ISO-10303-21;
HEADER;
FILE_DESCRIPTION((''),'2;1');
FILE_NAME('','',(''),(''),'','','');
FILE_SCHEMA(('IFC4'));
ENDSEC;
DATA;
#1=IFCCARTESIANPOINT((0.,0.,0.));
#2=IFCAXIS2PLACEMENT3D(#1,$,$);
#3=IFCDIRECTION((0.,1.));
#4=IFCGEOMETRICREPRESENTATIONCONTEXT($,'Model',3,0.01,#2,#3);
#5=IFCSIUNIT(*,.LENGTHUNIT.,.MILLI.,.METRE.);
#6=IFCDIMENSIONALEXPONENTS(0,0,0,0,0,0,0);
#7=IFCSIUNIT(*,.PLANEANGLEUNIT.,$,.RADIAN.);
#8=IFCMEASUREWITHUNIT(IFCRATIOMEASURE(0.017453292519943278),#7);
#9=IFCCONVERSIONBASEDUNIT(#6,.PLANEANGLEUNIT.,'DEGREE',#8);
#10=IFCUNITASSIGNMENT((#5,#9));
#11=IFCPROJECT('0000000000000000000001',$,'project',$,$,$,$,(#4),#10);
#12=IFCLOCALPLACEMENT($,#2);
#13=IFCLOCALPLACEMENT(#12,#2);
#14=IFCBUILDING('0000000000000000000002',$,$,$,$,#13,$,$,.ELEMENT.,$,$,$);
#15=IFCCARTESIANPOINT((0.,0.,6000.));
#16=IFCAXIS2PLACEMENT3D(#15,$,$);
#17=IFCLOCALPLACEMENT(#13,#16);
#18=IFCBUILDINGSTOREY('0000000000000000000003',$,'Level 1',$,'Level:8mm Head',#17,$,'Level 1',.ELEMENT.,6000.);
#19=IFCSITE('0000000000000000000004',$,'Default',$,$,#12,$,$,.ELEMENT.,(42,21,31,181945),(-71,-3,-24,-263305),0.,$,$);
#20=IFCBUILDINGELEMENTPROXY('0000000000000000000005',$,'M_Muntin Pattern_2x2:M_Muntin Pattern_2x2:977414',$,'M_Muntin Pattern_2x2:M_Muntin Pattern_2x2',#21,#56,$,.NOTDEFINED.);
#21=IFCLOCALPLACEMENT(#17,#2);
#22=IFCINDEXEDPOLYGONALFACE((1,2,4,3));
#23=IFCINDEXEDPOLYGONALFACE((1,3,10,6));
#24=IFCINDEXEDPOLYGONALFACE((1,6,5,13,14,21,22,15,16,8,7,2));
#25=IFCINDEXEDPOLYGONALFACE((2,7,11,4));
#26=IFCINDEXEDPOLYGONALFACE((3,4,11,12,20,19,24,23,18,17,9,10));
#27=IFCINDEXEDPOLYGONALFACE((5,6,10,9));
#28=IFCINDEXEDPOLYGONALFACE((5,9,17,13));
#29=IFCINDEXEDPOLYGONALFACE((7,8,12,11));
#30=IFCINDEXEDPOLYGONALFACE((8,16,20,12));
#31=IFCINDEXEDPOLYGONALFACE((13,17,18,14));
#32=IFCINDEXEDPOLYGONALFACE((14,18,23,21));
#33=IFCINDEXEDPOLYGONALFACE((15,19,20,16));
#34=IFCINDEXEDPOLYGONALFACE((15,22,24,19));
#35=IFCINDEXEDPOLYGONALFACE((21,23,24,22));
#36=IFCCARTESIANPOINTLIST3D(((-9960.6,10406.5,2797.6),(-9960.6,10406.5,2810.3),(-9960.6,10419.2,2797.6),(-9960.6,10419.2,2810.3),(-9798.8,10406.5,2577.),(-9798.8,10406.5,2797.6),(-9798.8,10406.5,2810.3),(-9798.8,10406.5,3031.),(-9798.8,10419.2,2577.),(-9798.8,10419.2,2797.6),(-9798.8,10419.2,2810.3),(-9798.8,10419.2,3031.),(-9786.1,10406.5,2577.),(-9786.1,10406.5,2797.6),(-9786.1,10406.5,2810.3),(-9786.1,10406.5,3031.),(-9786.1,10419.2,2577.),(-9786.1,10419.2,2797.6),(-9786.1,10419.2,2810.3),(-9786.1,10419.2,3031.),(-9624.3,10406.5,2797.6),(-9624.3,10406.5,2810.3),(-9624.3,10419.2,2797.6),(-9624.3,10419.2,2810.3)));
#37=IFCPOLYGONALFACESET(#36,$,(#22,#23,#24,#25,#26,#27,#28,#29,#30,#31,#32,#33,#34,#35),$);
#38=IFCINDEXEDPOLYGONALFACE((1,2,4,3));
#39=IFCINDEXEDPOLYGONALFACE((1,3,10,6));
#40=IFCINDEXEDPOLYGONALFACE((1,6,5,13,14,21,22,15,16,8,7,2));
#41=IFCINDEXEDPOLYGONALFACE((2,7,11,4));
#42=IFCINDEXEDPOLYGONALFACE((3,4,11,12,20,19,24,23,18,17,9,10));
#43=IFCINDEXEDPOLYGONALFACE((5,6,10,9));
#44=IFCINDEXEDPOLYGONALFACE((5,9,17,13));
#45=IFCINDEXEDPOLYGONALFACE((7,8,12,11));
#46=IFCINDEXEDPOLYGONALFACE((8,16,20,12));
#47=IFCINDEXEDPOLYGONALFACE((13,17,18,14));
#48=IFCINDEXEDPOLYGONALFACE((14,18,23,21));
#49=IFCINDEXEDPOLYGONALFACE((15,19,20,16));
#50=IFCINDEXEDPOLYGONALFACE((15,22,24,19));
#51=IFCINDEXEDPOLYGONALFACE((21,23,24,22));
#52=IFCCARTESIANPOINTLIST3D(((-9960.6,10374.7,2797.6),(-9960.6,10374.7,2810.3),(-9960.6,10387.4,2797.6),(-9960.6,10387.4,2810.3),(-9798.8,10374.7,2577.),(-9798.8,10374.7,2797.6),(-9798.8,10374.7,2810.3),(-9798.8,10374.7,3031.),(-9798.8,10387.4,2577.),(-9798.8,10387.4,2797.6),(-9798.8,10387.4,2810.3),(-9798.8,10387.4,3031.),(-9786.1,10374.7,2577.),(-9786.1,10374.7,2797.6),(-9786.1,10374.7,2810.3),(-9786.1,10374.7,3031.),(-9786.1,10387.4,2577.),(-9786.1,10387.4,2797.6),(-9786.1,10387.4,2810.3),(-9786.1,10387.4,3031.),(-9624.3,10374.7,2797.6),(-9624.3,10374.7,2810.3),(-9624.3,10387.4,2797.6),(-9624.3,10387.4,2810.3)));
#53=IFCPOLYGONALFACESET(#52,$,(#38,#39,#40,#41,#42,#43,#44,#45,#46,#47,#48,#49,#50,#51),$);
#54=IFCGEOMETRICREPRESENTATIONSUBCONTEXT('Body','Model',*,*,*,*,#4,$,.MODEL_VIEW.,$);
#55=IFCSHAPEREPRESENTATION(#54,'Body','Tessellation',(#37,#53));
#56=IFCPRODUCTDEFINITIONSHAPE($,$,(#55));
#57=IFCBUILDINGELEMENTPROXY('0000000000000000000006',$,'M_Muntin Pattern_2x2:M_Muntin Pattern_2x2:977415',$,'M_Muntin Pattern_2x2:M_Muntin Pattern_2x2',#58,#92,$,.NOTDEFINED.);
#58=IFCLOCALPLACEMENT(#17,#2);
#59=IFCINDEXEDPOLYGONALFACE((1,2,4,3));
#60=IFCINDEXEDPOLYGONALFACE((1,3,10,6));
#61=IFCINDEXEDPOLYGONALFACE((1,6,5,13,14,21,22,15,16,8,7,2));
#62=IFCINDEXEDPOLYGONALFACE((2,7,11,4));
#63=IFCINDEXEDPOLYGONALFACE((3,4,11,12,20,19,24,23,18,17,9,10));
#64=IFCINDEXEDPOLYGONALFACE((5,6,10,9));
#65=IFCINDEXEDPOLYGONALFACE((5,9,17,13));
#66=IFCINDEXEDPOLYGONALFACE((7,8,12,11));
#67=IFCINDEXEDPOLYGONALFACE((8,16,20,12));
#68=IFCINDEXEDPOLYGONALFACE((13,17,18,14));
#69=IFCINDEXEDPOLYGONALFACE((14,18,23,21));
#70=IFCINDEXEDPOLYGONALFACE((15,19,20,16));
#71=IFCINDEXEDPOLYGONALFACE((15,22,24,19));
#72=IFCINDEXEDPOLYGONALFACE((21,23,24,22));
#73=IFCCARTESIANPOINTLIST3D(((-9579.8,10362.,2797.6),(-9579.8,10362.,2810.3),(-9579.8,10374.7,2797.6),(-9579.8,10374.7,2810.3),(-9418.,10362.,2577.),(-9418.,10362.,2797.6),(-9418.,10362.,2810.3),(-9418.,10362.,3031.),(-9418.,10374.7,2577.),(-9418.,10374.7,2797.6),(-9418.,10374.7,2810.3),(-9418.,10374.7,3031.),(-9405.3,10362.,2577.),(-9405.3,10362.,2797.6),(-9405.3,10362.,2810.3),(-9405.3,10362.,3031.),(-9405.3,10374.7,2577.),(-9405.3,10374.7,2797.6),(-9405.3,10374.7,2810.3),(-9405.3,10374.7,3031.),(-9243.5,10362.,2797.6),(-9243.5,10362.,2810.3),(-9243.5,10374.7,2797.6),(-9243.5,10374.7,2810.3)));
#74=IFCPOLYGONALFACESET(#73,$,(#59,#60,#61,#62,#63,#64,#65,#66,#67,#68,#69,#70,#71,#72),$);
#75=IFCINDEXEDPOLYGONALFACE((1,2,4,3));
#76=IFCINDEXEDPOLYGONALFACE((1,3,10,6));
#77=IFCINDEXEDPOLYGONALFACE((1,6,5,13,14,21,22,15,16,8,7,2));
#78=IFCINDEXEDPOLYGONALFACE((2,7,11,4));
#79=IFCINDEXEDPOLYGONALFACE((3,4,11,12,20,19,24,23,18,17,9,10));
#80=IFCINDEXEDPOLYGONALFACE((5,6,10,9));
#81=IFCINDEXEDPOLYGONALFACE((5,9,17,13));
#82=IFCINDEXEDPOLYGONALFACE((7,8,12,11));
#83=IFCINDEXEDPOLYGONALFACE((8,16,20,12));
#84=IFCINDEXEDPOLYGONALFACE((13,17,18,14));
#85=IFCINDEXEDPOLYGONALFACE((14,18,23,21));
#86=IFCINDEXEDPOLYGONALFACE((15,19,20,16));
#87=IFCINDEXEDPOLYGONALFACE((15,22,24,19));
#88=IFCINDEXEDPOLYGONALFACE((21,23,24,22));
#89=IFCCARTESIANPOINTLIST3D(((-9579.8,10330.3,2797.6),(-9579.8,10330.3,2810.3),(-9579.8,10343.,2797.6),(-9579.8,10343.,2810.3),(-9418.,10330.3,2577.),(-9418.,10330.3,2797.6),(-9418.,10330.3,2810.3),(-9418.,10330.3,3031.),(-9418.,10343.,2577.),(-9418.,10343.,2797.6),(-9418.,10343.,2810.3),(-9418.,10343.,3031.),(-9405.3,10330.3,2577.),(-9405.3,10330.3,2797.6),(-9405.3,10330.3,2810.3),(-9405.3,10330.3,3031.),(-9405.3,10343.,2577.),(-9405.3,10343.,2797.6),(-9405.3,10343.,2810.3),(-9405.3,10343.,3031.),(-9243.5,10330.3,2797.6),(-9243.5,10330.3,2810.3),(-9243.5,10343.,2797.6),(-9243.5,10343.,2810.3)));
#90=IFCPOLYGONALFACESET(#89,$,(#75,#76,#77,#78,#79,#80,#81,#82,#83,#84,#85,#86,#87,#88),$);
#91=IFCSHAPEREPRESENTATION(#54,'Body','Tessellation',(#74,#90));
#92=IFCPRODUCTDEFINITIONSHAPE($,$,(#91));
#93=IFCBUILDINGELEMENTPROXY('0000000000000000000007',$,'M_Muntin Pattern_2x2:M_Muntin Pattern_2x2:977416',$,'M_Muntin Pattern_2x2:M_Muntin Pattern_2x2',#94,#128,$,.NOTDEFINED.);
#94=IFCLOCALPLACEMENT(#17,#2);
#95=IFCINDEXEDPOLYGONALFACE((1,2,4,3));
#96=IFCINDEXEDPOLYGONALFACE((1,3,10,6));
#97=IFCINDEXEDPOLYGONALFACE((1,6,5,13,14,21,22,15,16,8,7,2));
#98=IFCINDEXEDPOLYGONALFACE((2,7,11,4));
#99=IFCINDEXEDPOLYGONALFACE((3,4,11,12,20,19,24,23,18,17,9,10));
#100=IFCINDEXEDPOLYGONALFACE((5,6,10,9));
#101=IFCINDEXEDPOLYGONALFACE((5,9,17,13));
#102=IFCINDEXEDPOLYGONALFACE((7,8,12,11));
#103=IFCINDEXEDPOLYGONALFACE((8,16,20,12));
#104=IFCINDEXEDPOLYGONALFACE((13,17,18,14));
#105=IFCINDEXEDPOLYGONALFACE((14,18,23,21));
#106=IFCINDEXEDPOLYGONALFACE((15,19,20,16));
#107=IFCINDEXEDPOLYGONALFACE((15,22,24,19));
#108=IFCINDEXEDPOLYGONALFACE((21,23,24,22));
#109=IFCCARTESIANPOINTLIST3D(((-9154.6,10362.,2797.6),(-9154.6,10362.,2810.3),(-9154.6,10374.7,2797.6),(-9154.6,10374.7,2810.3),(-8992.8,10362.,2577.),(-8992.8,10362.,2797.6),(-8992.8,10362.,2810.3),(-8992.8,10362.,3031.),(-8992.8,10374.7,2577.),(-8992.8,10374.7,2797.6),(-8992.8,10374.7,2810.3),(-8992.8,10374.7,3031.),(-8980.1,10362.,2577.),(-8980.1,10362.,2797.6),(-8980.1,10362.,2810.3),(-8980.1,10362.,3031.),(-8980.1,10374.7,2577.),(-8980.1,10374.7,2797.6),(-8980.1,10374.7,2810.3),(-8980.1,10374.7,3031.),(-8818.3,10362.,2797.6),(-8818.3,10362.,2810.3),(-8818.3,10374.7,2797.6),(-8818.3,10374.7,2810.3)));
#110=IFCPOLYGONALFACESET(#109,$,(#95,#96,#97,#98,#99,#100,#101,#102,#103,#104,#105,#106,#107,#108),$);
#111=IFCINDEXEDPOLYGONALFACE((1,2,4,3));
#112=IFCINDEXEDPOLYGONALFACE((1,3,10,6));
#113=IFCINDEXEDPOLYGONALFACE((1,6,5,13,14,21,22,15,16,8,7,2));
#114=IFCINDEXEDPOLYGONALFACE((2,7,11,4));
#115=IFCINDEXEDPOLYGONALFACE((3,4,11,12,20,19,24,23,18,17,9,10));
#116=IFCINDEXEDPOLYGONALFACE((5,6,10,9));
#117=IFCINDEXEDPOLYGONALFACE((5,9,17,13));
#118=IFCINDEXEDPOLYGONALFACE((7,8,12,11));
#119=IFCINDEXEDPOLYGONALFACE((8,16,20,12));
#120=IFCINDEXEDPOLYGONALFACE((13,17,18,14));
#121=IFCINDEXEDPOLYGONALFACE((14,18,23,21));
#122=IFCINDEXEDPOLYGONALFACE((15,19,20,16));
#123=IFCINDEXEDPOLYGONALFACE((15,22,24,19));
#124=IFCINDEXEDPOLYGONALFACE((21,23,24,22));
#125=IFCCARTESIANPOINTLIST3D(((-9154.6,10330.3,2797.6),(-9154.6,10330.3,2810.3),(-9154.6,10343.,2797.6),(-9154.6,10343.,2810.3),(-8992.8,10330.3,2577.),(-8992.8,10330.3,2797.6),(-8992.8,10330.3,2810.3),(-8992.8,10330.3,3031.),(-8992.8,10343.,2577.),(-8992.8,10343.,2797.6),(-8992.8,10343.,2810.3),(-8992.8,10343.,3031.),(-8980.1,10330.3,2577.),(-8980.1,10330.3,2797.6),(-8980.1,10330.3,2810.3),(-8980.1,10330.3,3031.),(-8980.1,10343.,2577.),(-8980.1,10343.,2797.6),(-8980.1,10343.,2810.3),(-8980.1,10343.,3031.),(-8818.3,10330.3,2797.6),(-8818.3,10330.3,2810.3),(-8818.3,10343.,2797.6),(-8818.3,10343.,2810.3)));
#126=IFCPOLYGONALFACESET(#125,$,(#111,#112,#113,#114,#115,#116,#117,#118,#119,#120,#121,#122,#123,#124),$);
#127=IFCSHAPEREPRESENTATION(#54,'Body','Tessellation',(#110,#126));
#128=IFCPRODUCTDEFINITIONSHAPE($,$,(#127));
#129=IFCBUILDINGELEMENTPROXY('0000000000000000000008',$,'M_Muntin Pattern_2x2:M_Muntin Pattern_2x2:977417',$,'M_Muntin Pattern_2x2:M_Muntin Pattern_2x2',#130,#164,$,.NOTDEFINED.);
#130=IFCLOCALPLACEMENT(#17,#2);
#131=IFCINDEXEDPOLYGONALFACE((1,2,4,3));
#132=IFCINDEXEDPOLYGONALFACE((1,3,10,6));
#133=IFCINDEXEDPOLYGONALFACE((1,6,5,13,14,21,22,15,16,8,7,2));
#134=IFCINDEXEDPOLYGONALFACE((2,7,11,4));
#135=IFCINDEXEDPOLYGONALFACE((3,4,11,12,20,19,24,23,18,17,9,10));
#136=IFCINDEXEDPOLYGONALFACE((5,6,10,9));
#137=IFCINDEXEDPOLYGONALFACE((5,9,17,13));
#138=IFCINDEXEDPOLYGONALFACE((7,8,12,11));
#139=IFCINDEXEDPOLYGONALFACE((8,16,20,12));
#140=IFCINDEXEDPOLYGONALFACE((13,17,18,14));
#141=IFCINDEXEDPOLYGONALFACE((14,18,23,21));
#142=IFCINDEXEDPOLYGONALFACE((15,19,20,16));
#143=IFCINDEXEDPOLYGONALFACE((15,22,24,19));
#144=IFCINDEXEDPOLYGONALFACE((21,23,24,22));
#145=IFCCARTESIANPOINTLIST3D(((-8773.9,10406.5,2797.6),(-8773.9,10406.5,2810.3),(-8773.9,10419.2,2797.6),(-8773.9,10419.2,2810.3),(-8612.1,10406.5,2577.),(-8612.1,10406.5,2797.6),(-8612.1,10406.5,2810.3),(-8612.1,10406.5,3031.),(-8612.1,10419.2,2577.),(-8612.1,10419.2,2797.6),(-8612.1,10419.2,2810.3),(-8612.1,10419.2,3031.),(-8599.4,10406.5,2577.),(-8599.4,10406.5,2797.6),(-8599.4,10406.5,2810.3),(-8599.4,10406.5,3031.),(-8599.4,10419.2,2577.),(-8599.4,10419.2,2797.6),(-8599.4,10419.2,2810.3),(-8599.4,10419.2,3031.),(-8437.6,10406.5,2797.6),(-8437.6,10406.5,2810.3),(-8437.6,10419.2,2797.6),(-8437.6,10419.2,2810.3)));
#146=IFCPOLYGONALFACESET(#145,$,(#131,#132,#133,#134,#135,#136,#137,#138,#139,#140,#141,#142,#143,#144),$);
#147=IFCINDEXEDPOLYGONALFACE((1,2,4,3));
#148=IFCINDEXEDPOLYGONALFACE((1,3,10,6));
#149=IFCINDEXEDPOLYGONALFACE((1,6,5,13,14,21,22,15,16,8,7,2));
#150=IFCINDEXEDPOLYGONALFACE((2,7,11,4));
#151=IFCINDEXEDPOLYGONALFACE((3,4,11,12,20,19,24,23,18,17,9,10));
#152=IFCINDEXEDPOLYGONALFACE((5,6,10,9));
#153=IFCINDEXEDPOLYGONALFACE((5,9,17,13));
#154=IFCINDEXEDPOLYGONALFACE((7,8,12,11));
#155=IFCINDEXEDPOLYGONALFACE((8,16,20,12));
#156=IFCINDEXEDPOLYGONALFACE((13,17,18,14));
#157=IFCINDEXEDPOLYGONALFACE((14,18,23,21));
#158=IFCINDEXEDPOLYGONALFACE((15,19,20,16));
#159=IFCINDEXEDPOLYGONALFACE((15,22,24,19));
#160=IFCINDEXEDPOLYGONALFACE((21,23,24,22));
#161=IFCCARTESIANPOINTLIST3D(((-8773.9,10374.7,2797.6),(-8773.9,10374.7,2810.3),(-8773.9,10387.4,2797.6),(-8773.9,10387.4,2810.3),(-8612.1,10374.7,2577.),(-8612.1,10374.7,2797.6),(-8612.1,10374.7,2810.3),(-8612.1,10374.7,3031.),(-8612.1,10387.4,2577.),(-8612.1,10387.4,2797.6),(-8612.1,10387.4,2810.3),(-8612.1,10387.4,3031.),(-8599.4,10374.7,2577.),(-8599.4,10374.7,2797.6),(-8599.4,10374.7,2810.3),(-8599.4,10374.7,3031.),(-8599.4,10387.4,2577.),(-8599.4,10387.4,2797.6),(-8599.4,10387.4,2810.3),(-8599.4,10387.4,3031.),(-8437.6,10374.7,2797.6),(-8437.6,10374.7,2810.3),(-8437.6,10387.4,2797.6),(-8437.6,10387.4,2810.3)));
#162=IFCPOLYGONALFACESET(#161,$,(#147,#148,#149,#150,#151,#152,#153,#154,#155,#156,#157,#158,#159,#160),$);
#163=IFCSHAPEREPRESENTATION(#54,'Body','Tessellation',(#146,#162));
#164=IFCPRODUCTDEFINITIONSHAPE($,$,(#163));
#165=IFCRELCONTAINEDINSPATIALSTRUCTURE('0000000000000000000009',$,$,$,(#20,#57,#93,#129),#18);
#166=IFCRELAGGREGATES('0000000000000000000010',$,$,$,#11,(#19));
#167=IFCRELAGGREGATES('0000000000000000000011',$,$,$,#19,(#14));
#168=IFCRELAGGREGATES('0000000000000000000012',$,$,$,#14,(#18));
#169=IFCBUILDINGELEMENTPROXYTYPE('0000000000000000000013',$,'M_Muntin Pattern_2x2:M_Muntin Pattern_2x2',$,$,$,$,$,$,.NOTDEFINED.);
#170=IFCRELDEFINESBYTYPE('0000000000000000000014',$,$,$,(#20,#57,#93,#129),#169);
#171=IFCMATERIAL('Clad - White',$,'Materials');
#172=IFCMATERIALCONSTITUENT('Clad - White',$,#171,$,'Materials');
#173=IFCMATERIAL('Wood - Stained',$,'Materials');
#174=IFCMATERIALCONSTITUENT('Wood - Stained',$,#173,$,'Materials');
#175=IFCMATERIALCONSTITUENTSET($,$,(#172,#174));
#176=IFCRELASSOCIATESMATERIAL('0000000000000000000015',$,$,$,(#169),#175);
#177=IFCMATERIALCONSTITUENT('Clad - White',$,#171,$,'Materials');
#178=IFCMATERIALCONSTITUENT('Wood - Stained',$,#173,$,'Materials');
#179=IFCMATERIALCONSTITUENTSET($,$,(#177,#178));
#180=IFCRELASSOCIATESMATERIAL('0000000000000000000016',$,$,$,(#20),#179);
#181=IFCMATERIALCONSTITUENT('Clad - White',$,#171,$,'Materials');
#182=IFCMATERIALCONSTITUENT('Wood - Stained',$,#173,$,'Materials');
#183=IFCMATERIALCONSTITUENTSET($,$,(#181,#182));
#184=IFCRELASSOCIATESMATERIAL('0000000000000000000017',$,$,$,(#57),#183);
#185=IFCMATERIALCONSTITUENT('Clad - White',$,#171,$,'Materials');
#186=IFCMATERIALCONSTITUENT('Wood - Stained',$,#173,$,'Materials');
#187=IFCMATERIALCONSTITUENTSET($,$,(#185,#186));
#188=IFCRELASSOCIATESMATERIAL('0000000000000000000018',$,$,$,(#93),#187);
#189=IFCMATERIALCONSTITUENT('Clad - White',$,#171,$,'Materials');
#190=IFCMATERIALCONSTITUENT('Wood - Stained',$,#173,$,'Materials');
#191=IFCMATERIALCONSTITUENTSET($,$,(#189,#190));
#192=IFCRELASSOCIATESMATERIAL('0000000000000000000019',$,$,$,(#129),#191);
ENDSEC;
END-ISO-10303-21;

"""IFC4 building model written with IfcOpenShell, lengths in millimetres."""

from ifc_helpers import new_model, entity, si_unit, converted_unit, direction, frame, origin, place, context, subcontext, project, spatial, indexed_curve, outline, extrude, source, transform, mapped, material, constituent, constituent_set, type_object, type_shapes, element, save


model = new_model("IFC4")

# Units and contexts
model_context = context("Model", 3, precision=0.01, world=origin(), true_north=direction((0.0, 1.0)))
body_context = subcontext(model_context, "Body", "Model", "MODEL_VIEW")
ifc_project = project(units=[si_unit("LENGTHUNIT", "METRE", prefix="MILLI"), converted_unit("PLANEANGLEUNIT", "DEGREE", entity("IfcRatioMeasure", 0.017453292519943278), si_unit("PLANEANGLEUNIT", "RADIAN"), dimensions=[0, 0, 0, 0, 0, 0, 0])], contexts=[model_context])

# Site, building, storey
site_placement = place(None, origin())
site = spatial("IfcSite", under=ifc_project, at=site_placement, Name="Default", CompositionType="ELEMENT", RefLatitude=(42, 21, 31, 181945), RefLongitude=(-71, -3, -24, -263305), RefElevation=0.0)
building_placement = place(site_placement, origin())
building = spatial("IfcBuilding", under=site, at=building_placement, CompositionType="ELEMENT")
storey_placement = place(building_placement, frame((0.0, 0.0, 6000.0)))
storey = spatial("IfcBuildingStorey", under=building, at=storey_placement, Name="Level 1", ObjectType="Level:8mm Head", LongName="Level 1", CompositionType="ELEMENT", Elevation=6000.0)

# Building element proxies
ifc_material_1 = material(Name="Clad - White", Category="Materials")
ifc_material_2 = material(Name="Wood - Stained", Category="Materials")
ifc_constituent_1 = constituent(ifc_material_1, Name="Clad - White", Category="Materials")
ifc_constituent_2 = constituent(ifc_material_2, Name="Wood - Stained", Category="Materials")
ifc_constituent_set_1 = constituent_set(constituents=[ifc_constituent_1, ifc_constituent_2])
building_element_proxy_type_1 = type_object("IfcBuildingElementProxyType", Name="M_Muntin Pattern_2x2:M_Muntin Pattern_2x2", PredefinedType="NOTDEFINED", material=ifc_constituent_set_1)
shared_shape_1 = source(origin(), body_context, "Body", "SweptSolid", [
    extrude(outline(indexed_curve([(6.4, -6.4), (227.0, -6.4), (227.0, 6.3), (6.4, 6.3), (6.4, 168.2), (-6.3, 168.2), (-6.3, 6.3), (-227.0, 6.3), (-227.0, -6.4), (-6.3, -6.4), (-6.3, -168.1), (6.4, -168.1), (6.4, -6.4)], self_intersect=False)), frame((0.0, 9.5, 227.0), z_axis=(0.0, 1.0, 0.0), x_axis=(0.0, 0.0, 1.0)), (0.0, 0.0, 1.0), 12.7),
    extrude(outline(indexed_curve([(6.4, -6.4), (227.0, -6.4), (227.0, 6.3), (6.4, 6.3), (6.4, 168.2), (-6.3, 168.2), (-6.3, 6.3), (-227.0, 6.3), (-227.0, -6.4), (-6.3, -6.4), (-6.3, -168.1), (6.4, -168.1), (6.4, -6.4)], self_intersect=False)), frame((0.0, -22.2, 227.0), z_axis=(0.0, 1.0, 0.0), x_axis=(0.0, 0.0, 1.0)), (0.0, 0.0, 1.0), 12.7),
])
type_shapes(building_element_proxy_type_1, [shared_shape_1])
ifc_constituent_3 = constituent(ifc_material_1, Name="Clad - White", Category="Materials")
ifc_constituent_4 = constituent(ifc_material_2, Name="Wood - Stained", Category="Materials")
ifc_constituent_set_2 = constituent_set(constituents=[ifc_constituent_3, ifc_constituent_4])
proxy_1_placement = place(storey_placement, frame((-9792.4, 10396.9, 2577.0)))
element("IfcBuildingElementProxy", 1, at=proxy_1_placement, inside=storey, type_object=building_element_proxy_type_1, material=ifc_constituent_set_2, Name="M_Muntin Pattern_2x2:M_Muntin Pattern_2x2:977414", ObjectType="M_Muntin Pattern_2x2:M_Muntin Pattern_2x2", PredefinedType="NOTDEFINED", context=body_context, shape_type="MappedRepresentation", body=[
    mapped(shared_shape_1, transform((0.0, 0.0, 0.0), scale=1.0)),
])
ifc_constituent_5 = constituent(ifc_material_1, Name="Clad - White", Category="Materials")
ifc_constituent_6 = constituent(ifc_material_2, Name="Wood - Stained", Category="Materials")
ifc_constituent_set_3 = constituent_set(constituents=[ifc_constituent_5, ifc_constituent_6])
proxy_2_placement = place(storey_placement, frame((-9411.7, 10352.5, 2577.0)))
element("IfcBuildingElementProxy", 2, at=proxy_2_placement, inside=storey, type_object=building_element_proxy_type_1, material=ifc_constituent_set_3, Name="M_Muntin Pattern_2x2:M_Muntin Pattern_2x2:977415", ObjectType="M_Muntin Pattern_2x2:M_Muntin Pattern_2x2", PredefinedType="NOTDEFINED", context=body_context, shape_type="MappedRepresentation", body=[
    mapped(shared_shape_1, transform((0.0, 0.0, 0.0), scale=1.0)),
])
ifc_constituent_7 = constituent(ifc_material_1, Name="Clad - White", Category="Materials")
ifc_constituent_8 = constituent(ifc_material_2, Name="Wood - Stained", Category="Materials")
ifc_constituent_set_4 = constituent_set(constituents=[ifc_constituent_7, ifc_constituent_8])
proxy_3_placement = place(storey_placement, frame((-8986.5, 10352.5, 2577.0)))
element("IfcBuildingElementProxy", 3, at=proxy_3_placement, inside=storey, type_object=building_element_proxy_type_1, material=ifc_constituent_set_4, Name="M_Muntin Pattern_2x2:M_Muntin Pattern_2x2:977416", ObjectType="M_Muntin Pattern_2x2:M_Muntin Pattern_2x2", PredefinedType="NOTDEFINED", context=body_context, shape_type="MappedRepresentation", body=[
    mapped(shared_shape_1, transform((0.0, 0.0, 0.0), scale=1.0)),
])
ifc_constituent_9 = constituent(ifc_material_1, Name="Clad - White", Category="Materials")
ifc_constituent_10 = constituent(ifc_material_2, Name="Wood - Stained", Category="Materials")
ifc_constituent_set_5 = constituent_set(constituents=[ifc_constituent_9, ifc_constituent_10])
proxy_4_placement = place(storey_placement, frame((-8605.7, 10396.9, 2577.0)))
element("IfcBuildingElementProxy", 4, at=proxy_4_placement, inside=storey, type_object=building_element_proxy_type_1, material=ifc_constituent_set_5, Name="M_Muntin Pattern_2x2:M_Muntin Pattern_2x2:977417", ObjectType="M_Muntin Pattern_2x2:M_Muntin Pattern_2x2", PredefinedType="NOTDEFINED", context=body_context, shape_type="MappedRepresentation", body=[
    mapped(shared_shape_1, transform((0.0, 0.0, 0.0), scale=1.0)),
])

save(model, "model.ifc")
